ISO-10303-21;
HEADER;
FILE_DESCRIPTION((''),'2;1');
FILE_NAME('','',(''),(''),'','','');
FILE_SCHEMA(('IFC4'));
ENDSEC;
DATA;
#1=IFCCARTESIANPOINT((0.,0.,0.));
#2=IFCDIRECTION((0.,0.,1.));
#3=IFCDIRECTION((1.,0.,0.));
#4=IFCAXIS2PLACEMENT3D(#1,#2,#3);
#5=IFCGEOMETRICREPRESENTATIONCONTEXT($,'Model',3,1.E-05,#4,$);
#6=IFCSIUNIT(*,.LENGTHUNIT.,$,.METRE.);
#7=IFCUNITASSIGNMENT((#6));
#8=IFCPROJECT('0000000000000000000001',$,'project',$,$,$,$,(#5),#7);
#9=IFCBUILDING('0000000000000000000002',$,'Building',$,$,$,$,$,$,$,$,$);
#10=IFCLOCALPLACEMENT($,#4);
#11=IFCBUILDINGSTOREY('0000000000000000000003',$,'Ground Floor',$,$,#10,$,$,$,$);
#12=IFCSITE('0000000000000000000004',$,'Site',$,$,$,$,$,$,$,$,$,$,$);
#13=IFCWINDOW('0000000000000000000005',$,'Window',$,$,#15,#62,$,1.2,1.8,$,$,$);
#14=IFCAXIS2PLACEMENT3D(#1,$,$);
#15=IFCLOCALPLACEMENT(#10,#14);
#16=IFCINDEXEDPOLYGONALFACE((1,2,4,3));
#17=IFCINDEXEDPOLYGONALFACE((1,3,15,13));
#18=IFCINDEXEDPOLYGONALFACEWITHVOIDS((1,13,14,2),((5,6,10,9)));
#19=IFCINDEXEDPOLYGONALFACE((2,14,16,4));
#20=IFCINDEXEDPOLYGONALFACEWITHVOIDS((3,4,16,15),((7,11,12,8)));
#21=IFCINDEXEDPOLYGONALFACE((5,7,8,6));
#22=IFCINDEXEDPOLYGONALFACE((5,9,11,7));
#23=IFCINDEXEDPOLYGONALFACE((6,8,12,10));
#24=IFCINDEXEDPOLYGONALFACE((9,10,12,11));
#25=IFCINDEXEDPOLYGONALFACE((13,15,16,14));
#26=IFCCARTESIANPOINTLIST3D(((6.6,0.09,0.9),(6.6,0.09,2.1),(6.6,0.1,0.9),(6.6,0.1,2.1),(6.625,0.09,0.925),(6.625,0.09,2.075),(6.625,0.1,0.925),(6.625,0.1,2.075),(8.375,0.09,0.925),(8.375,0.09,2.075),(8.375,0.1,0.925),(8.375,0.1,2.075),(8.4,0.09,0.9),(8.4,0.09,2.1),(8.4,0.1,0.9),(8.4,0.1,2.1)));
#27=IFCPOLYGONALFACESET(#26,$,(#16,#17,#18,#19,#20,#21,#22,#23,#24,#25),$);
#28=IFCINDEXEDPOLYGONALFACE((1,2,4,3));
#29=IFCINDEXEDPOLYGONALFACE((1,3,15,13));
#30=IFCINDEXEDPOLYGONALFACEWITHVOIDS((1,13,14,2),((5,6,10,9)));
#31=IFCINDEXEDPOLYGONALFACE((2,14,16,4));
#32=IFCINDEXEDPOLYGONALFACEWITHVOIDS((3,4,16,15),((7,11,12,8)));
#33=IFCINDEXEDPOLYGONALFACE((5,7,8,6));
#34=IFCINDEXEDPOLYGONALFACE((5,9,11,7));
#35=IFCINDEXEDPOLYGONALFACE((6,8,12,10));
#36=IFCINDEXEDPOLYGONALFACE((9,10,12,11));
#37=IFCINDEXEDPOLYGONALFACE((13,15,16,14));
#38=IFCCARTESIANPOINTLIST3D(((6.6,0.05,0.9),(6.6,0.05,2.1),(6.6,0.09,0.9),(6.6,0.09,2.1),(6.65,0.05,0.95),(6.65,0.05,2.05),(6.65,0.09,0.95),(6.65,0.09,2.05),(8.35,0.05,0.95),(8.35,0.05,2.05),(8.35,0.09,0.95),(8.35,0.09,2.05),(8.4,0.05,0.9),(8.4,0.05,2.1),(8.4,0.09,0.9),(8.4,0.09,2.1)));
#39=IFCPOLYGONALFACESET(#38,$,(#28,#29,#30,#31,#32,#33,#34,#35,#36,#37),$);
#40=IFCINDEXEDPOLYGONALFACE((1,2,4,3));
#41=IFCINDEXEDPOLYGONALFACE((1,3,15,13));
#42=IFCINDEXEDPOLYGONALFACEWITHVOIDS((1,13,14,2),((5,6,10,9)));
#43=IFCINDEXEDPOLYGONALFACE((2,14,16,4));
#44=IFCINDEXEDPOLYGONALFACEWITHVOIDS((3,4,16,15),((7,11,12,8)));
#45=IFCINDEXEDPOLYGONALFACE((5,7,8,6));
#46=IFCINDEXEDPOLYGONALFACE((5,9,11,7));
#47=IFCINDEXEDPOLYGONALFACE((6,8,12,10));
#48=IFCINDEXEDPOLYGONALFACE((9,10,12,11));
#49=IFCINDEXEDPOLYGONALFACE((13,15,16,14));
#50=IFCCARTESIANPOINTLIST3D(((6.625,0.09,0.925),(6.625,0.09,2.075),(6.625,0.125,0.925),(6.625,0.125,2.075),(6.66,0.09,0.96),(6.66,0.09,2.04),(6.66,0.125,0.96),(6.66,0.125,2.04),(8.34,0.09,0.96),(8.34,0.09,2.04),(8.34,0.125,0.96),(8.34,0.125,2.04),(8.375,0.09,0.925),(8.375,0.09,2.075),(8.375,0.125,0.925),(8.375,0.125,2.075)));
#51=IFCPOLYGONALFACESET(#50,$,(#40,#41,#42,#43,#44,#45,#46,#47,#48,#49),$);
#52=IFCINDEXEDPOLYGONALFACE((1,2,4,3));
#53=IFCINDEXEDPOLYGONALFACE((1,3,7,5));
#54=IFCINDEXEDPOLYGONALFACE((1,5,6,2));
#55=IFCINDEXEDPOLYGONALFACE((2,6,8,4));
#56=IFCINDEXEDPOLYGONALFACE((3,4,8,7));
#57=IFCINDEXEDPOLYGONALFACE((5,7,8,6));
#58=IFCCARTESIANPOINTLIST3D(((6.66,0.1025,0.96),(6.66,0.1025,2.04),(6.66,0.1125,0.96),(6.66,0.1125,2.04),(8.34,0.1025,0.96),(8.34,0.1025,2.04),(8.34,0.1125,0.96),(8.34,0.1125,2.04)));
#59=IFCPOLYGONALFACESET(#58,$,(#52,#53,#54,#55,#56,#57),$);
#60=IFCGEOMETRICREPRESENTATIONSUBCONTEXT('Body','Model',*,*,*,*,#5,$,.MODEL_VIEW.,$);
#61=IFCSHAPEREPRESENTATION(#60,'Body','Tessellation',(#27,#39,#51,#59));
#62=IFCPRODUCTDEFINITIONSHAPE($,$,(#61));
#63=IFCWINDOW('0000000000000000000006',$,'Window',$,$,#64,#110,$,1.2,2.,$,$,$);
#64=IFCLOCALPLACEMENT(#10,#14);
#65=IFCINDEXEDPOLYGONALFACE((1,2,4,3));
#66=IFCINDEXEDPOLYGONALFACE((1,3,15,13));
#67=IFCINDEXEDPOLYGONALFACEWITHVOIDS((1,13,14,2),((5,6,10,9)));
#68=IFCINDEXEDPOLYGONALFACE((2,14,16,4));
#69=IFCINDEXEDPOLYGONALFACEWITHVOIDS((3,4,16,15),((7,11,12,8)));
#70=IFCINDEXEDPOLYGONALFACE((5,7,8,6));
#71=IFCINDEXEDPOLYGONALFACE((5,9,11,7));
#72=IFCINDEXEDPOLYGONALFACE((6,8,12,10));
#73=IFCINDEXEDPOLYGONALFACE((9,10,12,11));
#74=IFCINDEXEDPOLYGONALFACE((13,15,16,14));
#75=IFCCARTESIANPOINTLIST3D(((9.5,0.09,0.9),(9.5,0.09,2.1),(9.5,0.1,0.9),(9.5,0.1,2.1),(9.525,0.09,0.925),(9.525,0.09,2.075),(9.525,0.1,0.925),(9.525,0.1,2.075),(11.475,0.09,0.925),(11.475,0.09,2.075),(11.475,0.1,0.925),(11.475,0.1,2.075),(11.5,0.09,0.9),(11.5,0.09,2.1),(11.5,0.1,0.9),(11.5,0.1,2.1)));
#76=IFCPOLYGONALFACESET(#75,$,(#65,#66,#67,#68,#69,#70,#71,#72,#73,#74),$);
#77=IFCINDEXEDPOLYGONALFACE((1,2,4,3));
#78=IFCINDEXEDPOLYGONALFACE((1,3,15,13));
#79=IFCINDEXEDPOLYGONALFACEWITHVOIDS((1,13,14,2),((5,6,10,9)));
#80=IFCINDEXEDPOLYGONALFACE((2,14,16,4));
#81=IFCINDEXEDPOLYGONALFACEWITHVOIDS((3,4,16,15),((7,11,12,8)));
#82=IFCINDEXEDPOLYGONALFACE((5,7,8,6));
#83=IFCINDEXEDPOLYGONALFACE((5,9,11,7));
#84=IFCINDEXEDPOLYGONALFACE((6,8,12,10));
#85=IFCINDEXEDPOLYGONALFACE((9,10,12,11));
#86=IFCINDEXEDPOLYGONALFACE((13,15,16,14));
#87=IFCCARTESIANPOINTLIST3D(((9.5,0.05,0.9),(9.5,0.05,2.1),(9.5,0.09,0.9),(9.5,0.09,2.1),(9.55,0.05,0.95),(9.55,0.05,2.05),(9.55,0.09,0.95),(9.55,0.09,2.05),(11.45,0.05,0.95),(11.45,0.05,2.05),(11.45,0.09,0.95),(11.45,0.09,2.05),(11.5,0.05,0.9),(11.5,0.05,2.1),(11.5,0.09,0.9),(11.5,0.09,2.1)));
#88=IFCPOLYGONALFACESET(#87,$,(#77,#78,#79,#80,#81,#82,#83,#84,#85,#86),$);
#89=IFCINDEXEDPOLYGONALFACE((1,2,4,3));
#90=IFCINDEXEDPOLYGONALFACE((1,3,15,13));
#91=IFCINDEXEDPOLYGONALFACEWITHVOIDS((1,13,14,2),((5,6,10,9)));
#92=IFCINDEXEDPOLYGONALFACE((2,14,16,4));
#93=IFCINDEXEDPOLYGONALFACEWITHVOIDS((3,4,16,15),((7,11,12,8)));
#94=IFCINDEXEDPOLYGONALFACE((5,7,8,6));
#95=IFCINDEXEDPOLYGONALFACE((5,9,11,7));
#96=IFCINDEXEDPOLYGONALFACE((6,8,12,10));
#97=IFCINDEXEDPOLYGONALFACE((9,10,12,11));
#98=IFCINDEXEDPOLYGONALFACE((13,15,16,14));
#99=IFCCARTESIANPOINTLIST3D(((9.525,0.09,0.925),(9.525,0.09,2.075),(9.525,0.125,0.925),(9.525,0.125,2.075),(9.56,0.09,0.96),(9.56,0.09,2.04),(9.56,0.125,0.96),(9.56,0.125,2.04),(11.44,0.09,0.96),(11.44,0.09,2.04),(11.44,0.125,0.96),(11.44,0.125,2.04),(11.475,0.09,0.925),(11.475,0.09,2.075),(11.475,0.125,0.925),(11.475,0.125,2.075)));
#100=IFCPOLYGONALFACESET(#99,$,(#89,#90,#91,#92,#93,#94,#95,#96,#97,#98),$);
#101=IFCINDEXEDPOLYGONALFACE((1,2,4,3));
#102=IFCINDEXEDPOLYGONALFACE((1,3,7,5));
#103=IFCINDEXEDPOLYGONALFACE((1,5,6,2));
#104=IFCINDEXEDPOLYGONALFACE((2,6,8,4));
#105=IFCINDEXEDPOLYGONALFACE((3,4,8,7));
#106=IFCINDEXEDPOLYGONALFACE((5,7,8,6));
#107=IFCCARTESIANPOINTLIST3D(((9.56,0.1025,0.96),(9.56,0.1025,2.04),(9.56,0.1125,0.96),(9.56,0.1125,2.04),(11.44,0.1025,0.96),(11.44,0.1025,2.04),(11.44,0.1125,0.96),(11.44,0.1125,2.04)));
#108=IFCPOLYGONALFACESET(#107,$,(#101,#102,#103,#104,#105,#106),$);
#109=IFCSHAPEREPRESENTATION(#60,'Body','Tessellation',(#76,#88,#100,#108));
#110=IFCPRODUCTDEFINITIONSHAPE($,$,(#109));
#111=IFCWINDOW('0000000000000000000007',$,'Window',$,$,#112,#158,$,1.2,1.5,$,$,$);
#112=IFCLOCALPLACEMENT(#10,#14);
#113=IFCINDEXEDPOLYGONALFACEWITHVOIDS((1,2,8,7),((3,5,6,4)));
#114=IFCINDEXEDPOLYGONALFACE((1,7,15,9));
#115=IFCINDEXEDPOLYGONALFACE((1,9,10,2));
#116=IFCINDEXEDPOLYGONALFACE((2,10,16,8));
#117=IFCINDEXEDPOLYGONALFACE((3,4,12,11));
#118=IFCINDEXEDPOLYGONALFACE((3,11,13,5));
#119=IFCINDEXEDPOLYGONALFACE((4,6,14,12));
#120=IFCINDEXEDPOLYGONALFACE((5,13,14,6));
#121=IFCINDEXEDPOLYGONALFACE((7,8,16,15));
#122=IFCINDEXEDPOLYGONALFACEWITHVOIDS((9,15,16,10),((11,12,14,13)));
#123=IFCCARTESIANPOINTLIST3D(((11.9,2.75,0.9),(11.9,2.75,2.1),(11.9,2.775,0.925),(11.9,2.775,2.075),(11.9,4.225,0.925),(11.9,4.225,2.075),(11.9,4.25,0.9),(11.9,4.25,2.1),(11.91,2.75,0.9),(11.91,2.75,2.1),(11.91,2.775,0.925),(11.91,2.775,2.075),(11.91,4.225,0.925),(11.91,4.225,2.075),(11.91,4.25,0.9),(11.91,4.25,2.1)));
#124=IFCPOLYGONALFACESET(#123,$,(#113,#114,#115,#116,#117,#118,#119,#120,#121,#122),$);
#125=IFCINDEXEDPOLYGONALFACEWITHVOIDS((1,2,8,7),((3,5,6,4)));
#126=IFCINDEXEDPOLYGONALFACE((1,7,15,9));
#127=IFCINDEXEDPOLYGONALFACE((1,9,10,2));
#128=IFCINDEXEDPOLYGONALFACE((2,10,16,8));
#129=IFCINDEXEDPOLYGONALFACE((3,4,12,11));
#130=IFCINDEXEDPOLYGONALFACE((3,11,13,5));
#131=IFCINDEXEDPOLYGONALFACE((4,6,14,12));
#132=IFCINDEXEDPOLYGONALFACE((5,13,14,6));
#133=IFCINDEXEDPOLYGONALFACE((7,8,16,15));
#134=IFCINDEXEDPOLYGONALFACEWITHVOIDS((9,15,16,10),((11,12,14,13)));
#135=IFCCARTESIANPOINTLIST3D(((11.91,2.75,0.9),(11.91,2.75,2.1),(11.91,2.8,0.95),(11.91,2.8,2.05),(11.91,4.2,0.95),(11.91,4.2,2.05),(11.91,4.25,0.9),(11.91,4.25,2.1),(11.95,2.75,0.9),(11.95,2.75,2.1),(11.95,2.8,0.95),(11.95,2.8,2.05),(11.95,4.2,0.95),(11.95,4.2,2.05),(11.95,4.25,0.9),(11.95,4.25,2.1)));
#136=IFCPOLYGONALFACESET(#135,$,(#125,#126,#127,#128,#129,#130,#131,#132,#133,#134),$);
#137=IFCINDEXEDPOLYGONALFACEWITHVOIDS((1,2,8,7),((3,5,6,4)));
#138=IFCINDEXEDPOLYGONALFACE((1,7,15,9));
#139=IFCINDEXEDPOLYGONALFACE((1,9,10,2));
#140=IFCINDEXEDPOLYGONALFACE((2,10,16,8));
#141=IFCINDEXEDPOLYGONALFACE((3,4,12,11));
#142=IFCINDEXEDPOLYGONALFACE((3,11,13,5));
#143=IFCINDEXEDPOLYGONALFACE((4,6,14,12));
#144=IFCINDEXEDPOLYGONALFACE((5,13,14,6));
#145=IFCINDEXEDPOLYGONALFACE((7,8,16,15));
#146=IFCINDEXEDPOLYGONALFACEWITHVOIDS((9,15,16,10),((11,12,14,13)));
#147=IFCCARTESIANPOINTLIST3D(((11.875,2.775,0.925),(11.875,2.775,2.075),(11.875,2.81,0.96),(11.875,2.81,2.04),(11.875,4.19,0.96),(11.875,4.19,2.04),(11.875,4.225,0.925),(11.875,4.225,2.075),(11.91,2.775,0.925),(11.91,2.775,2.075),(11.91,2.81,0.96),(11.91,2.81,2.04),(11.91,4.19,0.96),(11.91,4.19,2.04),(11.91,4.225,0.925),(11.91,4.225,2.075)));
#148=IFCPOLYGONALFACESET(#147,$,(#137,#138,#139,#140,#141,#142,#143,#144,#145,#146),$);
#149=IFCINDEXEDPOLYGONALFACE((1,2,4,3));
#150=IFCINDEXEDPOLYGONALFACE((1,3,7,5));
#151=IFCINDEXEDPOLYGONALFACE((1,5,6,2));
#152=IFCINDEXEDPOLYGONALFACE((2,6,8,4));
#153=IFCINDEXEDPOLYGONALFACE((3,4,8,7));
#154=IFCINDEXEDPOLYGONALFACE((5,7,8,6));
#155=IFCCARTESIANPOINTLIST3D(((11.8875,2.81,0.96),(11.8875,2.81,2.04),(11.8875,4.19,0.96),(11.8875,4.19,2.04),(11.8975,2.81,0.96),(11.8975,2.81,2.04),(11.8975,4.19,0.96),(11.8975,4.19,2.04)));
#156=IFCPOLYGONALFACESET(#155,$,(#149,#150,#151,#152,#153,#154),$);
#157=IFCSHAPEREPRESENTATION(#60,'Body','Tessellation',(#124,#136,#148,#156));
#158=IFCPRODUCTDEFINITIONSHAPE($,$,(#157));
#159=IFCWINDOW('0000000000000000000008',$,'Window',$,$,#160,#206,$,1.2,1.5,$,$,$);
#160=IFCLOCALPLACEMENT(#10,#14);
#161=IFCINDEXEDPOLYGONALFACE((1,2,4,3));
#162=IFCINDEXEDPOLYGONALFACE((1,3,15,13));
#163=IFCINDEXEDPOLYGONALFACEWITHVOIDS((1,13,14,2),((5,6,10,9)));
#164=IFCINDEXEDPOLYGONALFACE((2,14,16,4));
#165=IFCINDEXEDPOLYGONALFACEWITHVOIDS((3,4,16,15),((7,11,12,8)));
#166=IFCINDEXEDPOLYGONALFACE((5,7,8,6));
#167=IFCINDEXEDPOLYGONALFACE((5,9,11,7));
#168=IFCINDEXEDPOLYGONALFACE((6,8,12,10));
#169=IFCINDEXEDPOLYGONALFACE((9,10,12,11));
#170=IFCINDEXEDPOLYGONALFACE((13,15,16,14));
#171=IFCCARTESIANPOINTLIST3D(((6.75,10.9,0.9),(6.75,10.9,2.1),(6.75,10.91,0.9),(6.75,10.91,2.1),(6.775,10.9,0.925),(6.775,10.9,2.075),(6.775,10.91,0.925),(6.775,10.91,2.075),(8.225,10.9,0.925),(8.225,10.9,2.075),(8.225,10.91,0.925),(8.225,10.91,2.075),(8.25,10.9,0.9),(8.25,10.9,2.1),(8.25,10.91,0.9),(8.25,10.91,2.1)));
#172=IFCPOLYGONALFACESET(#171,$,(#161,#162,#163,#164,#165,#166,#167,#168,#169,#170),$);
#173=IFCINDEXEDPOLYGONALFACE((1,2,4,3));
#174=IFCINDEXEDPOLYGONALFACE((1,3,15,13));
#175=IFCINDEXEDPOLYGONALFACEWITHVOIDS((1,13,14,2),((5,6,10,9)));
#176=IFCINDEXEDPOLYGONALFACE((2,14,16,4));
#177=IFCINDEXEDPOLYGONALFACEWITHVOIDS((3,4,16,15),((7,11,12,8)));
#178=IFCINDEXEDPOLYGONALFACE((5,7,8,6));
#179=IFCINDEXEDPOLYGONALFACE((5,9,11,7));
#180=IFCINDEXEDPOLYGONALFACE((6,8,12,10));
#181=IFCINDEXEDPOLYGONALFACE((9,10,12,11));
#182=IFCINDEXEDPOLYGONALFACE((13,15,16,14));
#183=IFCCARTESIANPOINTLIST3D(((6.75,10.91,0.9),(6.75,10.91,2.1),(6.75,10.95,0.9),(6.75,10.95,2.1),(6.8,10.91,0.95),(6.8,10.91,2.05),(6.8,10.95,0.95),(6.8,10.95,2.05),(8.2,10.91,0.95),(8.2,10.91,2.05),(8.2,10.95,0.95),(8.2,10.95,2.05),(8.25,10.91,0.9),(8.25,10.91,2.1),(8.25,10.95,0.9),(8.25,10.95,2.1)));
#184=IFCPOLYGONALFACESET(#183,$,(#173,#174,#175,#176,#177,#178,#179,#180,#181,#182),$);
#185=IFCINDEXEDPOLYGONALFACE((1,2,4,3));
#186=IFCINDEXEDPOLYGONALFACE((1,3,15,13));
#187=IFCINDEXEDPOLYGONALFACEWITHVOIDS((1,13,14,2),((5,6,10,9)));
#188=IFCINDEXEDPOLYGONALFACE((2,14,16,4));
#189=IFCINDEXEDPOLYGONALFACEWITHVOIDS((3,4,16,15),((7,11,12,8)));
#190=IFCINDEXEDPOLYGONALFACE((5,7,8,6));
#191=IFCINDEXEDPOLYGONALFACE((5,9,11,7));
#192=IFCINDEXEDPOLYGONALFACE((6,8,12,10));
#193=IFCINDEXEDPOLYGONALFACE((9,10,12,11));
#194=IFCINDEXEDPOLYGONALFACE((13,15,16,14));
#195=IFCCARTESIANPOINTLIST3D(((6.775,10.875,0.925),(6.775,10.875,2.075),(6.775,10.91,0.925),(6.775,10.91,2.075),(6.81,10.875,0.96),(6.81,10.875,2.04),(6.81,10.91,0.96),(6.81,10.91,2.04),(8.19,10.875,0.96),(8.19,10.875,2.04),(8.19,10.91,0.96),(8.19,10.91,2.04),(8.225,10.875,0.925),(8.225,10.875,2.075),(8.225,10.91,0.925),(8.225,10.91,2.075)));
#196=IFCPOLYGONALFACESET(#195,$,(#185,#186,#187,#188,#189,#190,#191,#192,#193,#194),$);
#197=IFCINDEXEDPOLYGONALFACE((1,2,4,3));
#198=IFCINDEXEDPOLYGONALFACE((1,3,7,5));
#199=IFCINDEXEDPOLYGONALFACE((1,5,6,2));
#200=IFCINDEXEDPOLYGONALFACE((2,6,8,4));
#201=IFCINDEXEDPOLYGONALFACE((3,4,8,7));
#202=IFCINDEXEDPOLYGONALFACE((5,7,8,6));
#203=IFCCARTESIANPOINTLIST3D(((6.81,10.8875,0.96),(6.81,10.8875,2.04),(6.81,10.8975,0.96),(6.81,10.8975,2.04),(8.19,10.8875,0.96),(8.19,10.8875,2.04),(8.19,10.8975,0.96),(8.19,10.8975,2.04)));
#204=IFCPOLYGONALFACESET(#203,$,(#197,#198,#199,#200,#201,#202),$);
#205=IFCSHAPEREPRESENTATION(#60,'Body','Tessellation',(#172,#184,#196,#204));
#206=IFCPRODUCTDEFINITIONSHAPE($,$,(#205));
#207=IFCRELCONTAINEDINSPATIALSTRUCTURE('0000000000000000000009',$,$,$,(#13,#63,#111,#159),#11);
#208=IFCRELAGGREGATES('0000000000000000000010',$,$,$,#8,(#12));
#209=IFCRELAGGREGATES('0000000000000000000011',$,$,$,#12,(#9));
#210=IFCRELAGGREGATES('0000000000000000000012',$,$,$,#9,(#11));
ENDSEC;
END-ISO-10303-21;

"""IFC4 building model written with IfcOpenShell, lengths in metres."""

from ifc_helpers import new_model, si_unit, frame, origin_with_axes, place, context, subcontext, project, spatial, line, indexed_curve, outline, extrude, element, save


model = new_model("IFC4")

# Units and contexts
model_context = context("Model", 3, precision=1e-05, world=origin_with_axes())
body_context = subcontext(model_context, "Body", "Model", "MODEL_VIEW")
ifc_project = project(units=[si_unit("LENGTHUNIT", "METRE")], contexts=[model_context])

# Site, building, storey
site = spatial("IfcSite", under=ifc_project, Name="Site")
building = spatial("IfcBuilding", under=site, Name="Building")
storey_placement = place(None, origin_with_axes())
storey = spatial("IfcBuildingStorey", under=building, at=storey_placement, Name="Ground Floor")

# Windows
window_1_placement = place(storey_placement, frame((6.6, 0.0, 0.9), z_axis=(0.0, 0.0, 1.0), x_axis=(1.0, 0.0, 0.0)))
element("IfcWindow", 1, at=window_1_placement, inside=storey, Name="Window", OverallHeight=1.2, OverallWidth=1.8, context=body_context, shape_type="SweptSolid", body=[
    extrude(outline(indexed_curve([(0.0, 0.0), (1.8, 0.0), (1.8, 1.2), (0.0, 1.2)], segments=[line(1, 2, 3, 4, 1)]), holes=[indexed_curve([(0.025, 0.025), (1.775, 0.025), (1.775, 1.175), (0.025, 1.175)], segments=[line(1, 2, 3, 4, 1)])]), frame((0.0, 0.09, 0.0), z_axis=(0.0, -1.0, 0.0), x_axis=(1.0, 0.0, 0.0)), (0.0, 0.0, -1.0), 0.01),
    extrude(outline(indexed_curve([(0.0, 0.0), (1.8, 0.0), (1.8, 1.2), (0.0, 1.2)], segments=[line(1, 2, 3, 4, 1)]), holes=[indexed_curve([(0.05, 0.05), (1.75, 0.05), (1.75, 1.15), (0.05, 1.15)], segments=[line(1, 2, 3, 4, 1)])]), frame((0.0, 0.05, 0.0), z_axis=(0.0, -1.0, 0.0), x_axis=(1.0, 0.0, 0.0)), (0.0, 0.0, -1.0), 0.04),
    extrude(outline(indexed_curve([(0.0, 0.0), (1.75, 0.0), (1.75, 1.15), (0.0, 1.15)], segments=[line(1, 2, 3, 4, 1)]), holes=[indexed_curve([(0.035, 0.035), (1.715, 0.035), (1.715, 1.115), (0.035, 1.115)], segments=[line(1, 2, 3, 4, 1)])]), frame((0.025, 0.09, 0.025), z_axis=(0.0, -1.0, 0.0), x_axis=(1.0, 0.0, 0.0)), (0.0, 0.0, -1.0), 0.035),
    extrude(outline(indexed_curve([(0.035, 0.035), (1.715, 0.035), (1.715, 1.115), (0.035, 1.115)], segments=[line(1, 2, 3, 4, 1)])), frame((0.025, 0.1025, 0.025), z_axis=(0.0, -1.0, 0.0), x_axis=(1.0, 0.0, 0.0)), (0.0, 0.0, -1.0), 0.01),
])
window_2_placement = place(storey_placement, frame((9.5, 0.0, 0.9), z_axis=(0.0, 0.0, 1.0), x_axis=(1.0, 0.0, 0.0)))
element("IfcWindow", 2, at=window_2_placement, inside=storey, Name="Window", OverallHeight=1.2, OverallWidth=2.0, context=body_context, shape_type="SweptSolid", body=[
    extrude(outline(indexed_curve([(0.0, 0.0), (2.0, 0.0), (2.0, 1.2), (0.0, 1.2)], segments=[line(1, 2, 3, 4, 1)]), holes=[indexed_curve([(0.025, 0.025), (1.975, 0.025), (1.975, 1.175), (0.025, 1.175)], segments=[line(1, 2, 3, 4, 1)])]), frame((0.0, 0.09, 0.0), z_axis=(0.0, -1.0, 0.0), x_axis=(1.0, 0.0, 0.0)), (0.0, 0.0, -1.0), 0.01),
    extrude(outline(indexed_curve([(0.0, 0.0), (2.0, 0.0), (2.0, 1.2), (0.0, 1.2)], segments=[line(1, 2, 3, 4, 1)]), holes=[indexed_curve([(0.05, 0.05), (1.95, 0.05), (1.95, 1.15), (0.05, 1.15)], segments=[line(1, 2, 3, 4, 1)])]), frame((0.0, 0.05, 0.0), z_axis=(0.0, -1.0, 0.0), x_axis=(1.0, 0.0, 0.0)), (0.0, 0.0, -1.0), 0.04),
    extrude(outline(indexed_curve([(0.0, 0.0), (1.95, 0.0), (1.95, 1.15), (0.0, 1.15)], segments=[line(1, 2, 3, 4, 1)]), holes=[indexed_curve([(0.035, 0.035), (1.915, 0.035), (1.915, 1.115), (0.035, 1.115)], segments=[line(1, 2, 3, 4, 1)])]), frame((0.025, 0.09, 0.025), z_axis=(0.0, -1.0, 0.0), x_axis=(1.0, 0.0, 0.0)), (0.0, 0.0, -1.0), 0.035),
    extrude(outline(indexed_curve([(0.035, 0.035), (1.915, 0.035), (1.915, 1.115), (0.035, 1.115)], segments=[line(1, 2, 3, 4, 1)])), frame((0.025, 0.1025, 0.025), z_axis=(0.0, -1.0, 0.0), x_axis=(1.0, 0.0, 0.0)), (0.0, 0.0, -1.0), 0.01),
])
for number, where, z_axis, x_axis, name in (
    (3, (12.0, 2.75, 0.9), (0.0, 0.0, 1.0), (0.0, 1.0, 0.0), "Window"),
    (4, (8.25, 11.0, 0.9), (0.0, 0.0, 1.0), (-1.0, 0.0, 0.0), "Window"),
):
    element("IfcWindow", number, at=place(storey_placement, frame(where, z_axis=z_axis, x_axis=x_axis)), inside=storey, Name=name, OverallHeight=1.2, OverallWidth=1.5, context=body_context, shape_type="SweptSolid", body=[
        extrude(outline(indexed_curve([(0.0, 0.0), (1.5, 0.0), (1.5, 1.2), (0.0, 1.2)], segments=[line(1, 2, 3, 4, 1)]), holes=[indexed_curve([(0.025, 0.025), (1.475, 0.025), (1.475, 1.175), (0.025, 1.175)], segments=[line(1, 2, 3, 4, 1)])]), frame((0.0, 0.09, 0.0), z_axis=(0.0, -1.0, 0.0), x_axis=(1.0, 0.0, 0.0)), (0.0, 0.0, -1.0), 0.01),
        extrude(outline(indexed_curve([(0.0, 0.0), (1.5, 0.0), (1.5, 1.2), (0.0, 1.2)], segments=[line(1, 2, 3, 4, 1)]), holes=[indexed_curve([(0.05, 0.05), (1.45, 0.05), (1.45, 1.15), (0.05, 1.15)], segments=[line(1, 2, 3, 4, 1)])]), frame((0.0, 0.05, 0.0), z_axis=(0.0, -1.0, 0.0), x_axis=(1.0, 0.0, 0.0)), (0.0, 0.0, -1.0), 0.04),
        extrude(outline(indexed_curve([(0.0, 0.0), (1.45, 0.0), (1.45, 1.15), (0.0, 1.15)], segments=[line(1, 2, 3, 4, 1)]), holes=[indexed_curve([(0.035, 0.035), (1.415, 0.035), (1.415, 1.115), (0.035, 1.115)], segments=[line(1, 2, 3, 4, 1)])]), frame((0.025, 0.09, 0.025), z_axis=(0.0, -1.0, 0.0), x_axis=(1.0, 0.0, 0.0)), (0.0, 0.0, -1.0), 0.035),
        extrude(outline(indexed_curve([(0.035, 0.035), (1.415, 0.035), (1.415, 1.115), (0.035, 1.115)], segments=[line(1, 2, 3, 4, 1)])), frame((0.025, 0.1025, 0.025), z_axis=(0.0, -1.0, 0.0), x_axis=(1.0, 0.0, 0.0)), (0.0, 0.0, -1.0), 0.01),
    ])

save(model, "model.ifc")
